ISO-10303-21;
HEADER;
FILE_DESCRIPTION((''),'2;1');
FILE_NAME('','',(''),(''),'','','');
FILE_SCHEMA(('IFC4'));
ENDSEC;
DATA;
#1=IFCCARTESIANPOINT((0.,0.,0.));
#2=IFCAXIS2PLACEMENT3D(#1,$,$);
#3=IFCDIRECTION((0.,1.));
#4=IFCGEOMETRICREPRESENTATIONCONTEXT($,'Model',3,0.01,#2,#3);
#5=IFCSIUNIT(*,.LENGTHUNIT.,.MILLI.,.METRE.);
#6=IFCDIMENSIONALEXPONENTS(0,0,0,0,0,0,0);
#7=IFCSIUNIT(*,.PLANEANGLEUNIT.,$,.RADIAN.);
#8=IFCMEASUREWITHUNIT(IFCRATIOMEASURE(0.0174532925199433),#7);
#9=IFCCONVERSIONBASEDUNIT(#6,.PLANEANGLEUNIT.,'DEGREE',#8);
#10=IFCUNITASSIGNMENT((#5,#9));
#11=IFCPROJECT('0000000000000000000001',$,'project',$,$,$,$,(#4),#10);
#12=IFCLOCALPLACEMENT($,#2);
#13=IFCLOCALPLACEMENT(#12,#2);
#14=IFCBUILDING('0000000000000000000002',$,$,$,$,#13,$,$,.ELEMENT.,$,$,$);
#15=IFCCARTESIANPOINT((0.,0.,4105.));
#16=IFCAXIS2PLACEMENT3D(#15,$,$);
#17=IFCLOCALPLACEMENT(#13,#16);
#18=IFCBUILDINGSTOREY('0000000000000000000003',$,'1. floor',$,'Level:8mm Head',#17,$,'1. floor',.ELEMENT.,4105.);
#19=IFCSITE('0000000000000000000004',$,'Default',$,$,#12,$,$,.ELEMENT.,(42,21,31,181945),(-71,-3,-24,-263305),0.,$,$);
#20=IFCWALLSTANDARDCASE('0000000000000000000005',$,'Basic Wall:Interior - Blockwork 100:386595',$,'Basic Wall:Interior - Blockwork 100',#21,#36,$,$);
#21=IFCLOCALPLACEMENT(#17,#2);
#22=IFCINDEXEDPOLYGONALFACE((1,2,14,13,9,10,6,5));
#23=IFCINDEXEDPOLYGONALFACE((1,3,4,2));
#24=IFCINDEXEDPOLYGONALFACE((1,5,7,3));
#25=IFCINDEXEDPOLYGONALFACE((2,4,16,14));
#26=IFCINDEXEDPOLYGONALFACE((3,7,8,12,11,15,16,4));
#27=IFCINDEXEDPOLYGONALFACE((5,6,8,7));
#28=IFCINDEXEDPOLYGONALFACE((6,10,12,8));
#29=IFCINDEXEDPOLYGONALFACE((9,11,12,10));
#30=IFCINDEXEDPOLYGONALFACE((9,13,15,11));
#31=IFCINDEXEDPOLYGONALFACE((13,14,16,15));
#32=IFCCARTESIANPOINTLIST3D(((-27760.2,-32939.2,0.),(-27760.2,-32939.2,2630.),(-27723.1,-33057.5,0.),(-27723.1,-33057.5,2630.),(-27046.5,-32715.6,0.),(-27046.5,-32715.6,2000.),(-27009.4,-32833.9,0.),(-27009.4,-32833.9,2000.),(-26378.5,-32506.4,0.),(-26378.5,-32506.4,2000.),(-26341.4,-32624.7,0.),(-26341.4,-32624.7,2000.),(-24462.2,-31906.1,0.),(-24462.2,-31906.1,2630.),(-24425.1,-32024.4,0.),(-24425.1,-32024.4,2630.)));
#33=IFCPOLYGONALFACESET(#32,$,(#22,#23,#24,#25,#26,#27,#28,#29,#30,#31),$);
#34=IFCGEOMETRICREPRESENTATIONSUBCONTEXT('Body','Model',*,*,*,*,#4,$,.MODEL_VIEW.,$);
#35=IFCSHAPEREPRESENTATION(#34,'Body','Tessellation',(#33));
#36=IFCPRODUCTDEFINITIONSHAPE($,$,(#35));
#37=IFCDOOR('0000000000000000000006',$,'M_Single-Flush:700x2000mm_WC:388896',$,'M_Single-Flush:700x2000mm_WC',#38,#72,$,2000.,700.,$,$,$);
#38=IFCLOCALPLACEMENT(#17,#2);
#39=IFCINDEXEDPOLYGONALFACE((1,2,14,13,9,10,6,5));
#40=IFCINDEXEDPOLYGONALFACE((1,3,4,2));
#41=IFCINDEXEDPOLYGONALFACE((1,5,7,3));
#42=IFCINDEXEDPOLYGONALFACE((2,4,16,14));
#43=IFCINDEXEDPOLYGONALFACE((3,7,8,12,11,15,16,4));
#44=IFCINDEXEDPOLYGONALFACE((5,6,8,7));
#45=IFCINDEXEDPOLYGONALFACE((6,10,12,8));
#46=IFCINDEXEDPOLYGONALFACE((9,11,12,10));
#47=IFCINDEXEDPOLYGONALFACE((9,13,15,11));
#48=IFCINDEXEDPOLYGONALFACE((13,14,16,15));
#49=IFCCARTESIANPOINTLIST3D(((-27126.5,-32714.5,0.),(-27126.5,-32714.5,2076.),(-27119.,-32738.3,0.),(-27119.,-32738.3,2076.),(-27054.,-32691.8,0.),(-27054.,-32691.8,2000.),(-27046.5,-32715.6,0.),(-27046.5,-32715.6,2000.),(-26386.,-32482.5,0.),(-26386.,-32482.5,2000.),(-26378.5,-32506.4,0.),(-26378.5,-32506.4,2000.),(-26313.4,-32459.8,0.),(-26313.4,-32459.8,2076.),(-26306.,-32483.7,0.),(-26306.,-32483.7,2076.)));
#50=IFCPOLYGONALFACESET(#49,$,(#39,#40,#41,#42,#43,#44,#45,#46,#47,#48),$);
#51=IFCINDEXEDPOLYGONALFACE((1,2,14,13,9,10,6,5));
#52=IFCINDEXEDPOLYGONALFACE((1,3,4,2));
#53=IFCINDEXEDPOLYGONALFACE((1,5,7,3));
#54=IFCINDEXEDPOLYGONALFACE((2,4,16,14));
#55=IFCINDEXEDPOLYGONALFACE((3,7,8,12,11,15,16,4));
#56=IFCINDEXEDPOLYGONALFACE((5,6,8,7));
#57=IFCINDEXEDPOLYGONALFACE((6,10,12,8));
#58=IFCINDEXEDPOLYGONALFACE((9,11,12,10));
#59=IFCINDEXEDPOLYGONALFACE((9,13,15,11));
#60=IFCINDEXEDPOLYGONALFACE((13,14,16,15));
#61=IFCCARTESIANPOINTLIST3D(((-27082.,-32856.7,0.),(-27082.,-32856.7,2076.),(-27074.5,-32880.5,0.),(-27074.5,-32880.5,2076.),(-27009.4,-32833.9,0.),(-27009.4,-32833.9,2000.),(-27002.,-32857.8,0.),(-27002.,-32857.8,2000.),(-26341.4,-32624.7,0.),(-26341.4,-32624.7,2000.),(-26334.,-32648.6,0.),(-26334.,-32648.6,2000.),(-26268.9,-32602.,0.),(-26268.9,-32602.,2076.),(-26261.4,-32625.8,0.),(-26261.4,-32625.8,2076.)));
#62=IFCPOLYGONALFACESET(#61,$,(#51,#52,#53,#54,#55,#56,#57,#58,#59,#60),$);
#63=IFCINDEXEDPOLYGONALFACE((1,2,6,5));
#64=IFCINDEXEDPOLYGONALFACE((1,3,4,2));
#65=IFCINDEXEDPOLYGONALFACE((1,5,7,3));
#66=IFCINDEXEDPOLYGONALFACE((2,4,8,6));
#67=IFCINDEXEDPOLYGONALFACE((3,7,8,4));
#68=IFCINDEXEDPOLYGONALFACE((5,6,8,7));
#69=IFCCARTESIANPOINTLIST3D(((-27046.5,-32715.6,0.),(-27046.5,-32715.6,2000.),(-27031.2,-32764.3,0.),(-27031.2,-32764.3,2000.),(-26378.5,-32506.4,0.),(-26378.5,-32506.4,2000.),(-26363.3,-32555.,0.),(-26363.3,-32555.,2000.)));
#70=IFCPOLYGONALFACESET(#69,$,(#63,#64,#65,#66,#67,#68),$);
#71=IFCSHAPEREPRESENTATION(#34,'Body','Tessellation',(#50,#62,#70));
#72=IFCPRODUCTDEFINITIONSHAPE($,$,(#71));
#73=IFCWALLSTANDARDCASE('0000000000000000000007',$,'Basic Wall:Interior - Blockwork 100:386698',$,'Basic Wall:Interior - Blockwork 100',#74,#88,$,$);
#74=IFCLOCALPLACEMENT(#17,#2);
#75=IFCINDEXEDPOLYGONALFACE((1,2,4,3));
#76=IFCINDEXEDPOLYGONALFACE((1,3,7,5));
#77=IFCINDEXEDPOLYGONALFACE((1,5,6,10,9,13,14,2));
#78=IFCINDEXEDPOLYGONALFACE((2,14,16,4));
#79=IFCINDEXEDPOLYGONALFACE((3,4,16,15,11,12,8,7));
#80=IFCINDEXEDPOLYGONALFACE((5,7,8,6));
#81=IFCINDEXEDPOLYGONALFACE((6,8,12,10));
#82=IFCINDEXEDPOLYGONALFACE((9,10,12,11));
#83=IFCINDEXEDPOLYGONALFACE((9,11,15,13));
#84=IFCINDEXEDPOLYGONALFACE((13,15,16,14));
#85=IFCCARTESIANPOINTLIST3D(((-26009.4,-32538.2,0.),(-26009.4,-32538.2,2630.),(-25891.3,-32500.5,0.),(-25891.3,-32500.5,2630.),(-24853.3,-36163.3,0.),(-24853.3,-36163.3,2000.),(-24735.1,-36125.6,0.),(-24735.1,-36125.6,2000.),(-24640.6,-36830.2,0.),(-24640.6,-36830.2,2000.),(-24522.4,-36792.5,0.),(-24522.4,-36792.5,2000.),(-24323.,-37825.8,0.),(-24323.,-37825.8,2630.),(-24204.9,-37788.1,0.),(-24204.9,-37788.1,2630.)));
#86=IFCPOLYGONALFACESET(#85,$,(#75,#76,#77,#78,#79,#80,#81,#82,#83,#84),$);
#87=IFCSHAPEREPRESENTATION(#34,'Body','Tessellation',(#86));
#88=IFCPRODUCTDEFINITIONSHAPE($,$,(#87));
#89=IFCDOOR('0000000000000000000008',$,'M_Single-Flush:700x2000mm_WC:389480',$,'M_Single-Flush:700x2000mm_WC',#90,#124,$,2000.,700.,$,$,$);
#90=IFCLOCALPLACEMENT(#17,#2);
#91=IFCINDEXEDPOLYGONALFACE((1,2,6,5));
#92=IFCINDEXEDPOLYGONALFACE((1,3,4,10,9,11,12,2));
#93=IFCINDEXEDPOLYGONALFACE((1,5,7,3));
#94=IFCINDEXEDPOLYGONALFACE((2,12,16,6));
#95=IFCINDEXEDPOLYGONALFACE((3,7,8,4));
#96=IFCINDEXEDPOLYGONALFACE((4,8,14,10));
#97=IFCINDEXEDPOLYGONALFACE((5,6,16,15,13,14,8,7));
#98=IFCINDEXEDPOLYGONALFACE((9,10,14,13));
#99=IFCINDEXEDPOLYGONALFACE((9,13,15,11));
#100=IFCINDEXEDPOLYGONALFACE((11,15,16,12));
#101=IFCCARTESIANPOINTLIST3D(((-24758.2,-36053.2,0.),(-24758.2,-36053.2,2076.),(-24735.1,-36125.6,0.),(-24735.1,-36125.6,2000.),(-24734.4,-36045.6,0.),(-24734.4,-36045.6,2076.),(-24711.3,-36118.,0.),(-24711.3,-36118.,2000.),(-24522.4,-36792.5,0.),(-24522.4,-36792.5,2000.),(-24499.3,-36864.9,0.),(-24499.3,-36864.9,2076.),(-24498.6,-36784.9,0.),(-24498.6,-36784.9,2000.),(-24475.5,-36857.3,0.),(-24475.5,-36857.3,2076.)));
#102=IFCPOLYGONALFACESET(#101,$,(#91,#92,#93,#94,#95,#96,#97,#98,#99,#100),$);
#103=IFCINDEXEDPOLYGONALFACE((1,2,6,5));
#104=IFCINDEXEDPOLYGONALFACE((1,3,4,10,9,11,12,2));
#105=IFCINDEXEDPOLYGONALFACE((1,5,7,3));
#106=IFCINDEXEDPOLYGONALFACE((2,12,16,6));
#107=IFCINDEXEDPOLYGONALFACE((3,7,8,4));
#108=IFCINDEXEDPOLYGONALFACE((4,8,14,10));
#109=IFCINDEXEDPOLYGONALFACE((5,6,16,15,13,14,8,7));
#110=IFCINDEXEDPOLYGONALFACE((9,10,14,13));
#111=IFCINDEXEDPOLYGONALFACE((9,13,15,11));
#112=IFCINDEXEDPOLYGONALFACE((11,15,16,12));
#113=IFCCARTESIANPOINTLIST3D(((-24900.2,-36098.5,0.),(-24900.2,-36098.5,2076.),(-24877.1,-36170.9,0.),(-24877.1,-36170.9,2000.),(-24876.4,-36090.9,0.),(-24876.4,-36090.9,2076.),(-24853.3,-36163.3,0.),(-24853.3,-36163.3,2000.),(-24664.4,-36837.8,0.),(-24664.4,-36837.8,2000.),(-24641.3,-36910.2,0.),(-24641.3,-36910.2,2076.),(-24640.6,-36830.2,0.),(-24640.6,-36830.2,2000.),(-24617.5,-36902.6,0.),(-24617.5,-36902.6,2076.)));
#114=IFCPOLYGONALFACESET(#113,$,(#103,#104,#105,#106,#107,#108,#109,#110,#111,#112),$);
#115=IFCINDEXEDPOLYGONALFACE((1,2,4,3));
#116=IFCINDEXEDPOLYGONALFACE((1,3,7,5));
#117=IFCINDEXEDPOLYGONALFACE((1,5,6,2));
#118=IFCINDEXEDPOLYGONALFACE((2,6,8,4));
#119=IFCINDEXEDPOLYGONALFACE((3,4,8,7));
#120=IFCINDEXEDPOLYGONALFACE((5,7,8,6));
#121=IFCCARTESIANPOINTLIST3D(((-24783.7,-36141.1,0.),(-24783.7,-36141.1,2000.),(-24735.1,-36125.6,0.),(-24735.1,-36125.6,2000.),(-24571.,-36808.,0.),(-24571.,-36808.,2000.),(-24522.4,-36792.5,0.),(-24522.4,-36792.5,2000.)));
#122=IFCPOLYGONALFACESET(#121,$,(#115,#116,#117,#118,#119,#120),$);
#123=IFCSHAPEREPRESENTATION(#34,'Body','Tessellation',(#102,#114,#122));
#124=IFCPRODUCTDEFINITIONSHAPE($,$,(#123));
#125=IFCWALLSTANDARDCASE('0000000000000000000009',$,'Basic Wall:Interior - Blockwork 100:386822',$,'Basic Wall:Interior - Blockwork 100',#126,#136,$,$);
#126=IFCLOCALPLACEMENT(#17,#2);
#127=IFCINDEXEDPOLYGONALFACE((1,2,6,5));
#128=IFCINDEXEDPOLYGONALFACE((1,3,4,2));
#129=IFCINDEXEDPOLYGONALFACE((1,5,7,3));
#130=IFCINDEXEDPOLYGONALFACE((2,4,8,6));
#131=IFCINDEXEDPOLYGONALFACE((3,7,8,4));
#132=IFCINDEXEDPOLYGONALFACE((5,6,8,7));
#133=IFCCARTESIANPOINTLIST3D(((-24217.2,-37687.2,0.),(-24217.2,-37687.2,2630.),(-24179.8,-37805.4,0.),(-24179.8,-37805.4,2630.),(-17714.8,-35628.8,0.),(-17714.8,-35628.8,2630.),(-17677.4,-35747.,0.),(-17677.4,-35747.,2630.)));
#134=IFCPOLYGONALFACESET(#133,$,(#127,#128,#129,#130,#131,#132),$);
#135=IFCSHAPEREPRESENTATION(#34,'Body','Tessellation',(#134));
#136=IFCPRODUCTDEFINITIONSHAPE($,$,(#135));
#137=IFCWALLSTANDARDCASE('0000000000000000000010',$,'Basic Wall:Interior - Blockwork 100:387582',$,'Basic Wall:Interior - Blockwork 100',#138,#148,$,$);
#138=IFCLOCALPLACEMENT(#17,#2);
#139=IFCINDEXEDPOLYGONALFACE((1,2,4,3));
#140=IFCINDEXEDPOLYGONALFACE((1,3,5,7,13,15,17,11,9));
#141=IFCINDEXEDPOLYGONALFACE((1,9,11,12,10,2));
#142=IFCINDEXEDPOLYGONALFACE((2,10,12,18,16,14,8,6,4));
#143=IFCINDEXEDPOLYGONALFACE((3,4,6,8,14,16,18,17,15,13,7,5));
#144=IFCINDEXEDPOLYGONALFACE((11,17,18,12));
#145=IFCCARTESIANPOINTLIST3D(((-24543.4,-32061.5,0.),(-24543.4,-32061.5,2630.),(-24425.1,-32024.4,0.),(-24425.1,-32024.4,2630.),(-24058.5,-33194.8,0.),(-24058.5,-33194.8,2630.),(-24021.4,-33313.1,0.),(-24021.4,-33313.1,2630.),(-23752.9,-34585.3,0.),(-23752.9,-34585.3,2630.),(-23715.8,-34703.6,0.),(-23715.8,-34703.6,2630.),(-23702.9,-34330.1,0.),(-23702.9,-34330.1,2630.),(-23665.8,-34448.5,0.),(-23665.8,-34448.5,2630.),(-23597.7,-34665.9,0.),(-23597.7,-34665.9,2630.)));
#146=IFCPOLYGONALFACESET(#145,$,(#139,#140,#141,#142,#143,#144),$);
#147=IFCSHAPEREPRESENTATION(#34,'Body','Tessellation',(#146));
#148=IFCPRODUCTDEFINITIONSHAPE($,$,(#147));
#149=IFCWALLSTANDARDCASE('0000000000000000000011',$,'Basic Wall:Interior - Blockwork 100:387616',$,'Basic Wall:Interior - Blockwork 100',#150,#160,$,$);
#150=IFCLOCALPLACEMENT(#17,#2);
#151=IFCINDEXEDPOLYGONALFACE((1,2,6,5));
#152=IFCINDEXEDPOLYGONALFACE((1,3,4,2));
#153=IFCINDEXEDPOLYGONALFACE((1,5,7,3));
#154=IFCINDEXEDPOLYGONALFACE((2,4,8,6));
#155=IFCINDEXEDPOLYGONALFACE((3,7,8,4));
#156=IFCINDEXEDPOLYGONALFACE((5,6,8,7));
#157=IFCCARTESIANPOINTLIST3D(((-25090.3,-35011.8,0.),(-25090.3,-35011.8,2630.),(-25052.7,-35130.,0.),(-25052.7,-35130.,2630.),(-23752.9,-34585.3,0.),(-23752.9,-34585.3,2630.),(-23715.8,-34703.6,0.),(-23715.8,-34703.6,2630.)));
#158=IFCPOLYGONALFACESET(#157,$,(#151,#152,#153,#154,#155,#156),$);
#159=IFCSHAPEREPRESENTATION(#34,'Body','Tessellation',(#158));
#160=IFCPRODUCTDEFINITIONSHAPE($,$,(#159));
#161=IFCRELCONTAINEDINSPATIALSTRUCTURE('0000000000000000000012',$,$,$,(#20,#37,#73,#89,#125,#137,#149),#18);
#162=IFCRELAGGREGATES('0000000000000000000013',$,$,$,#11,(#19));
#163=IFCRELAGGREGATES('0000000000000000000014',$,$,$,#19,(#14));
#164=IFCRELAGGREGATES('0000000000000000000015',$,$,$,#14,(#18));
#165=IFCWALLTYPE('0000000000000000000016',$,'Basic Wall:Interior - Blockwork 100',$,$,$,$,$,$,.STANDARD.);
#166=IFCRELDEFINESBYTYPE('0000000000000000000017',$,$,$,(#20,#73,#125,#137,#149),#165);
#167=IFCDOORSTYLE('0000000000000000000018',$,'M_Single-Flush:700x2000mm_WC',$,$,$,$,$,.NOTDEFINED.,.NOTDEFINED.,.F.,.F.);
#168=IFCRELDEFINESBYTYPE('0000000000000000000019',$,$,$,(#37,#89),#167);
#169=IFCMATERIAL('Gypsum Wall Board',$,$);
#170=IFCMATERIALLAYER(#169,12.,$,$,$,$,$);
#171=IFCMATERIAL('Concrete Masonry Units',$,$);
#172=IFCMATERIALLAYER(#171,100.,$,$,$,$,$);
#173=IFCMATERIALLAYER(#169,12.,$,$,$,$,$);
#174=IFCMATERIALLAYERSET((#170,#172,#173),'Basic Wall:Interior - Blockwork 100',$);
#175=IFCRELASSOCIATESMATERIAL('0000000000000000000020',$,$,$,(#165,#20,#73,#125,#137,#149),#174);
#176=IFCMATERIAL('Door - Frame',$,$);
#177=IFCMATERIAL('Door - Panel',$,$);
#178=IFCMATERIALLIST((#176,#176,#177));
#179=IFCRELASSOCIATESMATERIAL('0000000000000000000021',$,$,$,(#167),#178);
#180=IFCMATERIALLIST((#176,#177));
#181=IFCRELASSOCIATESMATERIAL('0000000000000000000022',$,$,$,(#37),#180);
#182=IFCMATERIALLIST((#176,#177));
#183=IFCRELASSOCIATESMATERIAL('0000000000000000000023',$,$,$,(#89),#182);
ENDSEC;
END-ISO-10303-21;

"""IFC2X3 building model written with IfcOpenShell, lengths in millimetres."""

from ifc_helpers import new_model, entity, si_unit, converted_unit, direction, frame, frame_2d, origin, origin_2d_with_axis, place, context, subcontext, project, spatial, polyline, rectangle, outline, extrude, source, transform, mapped, material, material_list, layer, layer_set, layer_usage, type_object, type_shapes, element, fill, save


model = new_model("IFC2X3")

# Units and contexts
model_context = context("Model", 3, precision=0.01, world=origin(), true_north=direction((0.0, 1.0)))
body_context = subcontext(model_context, "Body", "Model", "MODEL_VIEW")
ifc_project = project(units=[si_unit("LENGTHUNIT", "METRE", prefix="MILLI"), converted_unit("PLANEANGLEUNIT", "DEGREE", entity("IfcRatioMeasure", 0.0174532925199433), si_unit("PLANEANGLEUNIT", "RADIAN"), dimensions=[0, 0, 0, 0, 0, 0, 0])], contexts=[model_context])

# Site, building, storey
site_placement = place(None, origin())
site = spatial("IfcSite", under=ifc_project, at=site_placement, Name="Default", CompositionType="ELEMENT", RefLatitude=(42, 21, 31, 181945), RefLongitude=(-71, -3, -24, -263305), RefElevation=0.0)
building_placement = place(site_placement, origin())
building = spatial("IfcBuilding", under=site, at=building_placement, CompositionType="ELEMENT")
storey_placement = place(building_placement, frame((0.0, 0.0, 4105.0)))
storey = spatial("IfcBuildingStorey", under=building, at=storey_placement, Name="1. floor", ObjectType="Level:8mm Head", LongName="1. floor", CompositionType="ELEMENT", Elevation=4105.0)

# Walls, openings, doors
ifc_material_1 = material(Name="Gypsum Wall Board")
ifc_layer_1 = layer(ifc_material_1, 12.0)
ifc_material_2 = material(Name="Concrete Masonry Units")
ifc_layer_2 = layer(ifc_material_2, 100.0)
ifc_layer_3 = layer(ifc_material_1, 12.0)
ifc_layer_set = layer_set([ifc_layer_1, ifc_layer_2, ifc_layer_3], Name="Basic Wall:Interior - Blockwork 100")
ifc_layer_usage_1 = layer_usage(ifc_layer_set, "AXIS2", "NEGATIVE", 62.0)
wall_type = type_object("IfcWallType", Name="Basic Wall:Interior - Blockwork 100", PredefinedType="STANDARD", material=ifc_layer_set)
wall_1_placement = place(storey_placement, frame((-27741.6, -32998.3, 0.0), z_axis=(0.0, 0.0, 1.0), x_axis=(0.954277, 0.298924, 0.0)))
wall_1 = element("IfcWallStandardCase", 1, at=wall_1_placement, inside=storey, type_object=wall_type, material=ifc_layer_usage_1, Name="Basic Wall:Interior - Blockwork 100:386595", ObjectType="Basic Wall:Interior - Blockwork 100", context=body_context, shape_type="SweptSolid", body=[
    extrude(rectangle(XDim=3456.0, YDim=124.0, at=frame_2d((1728.0, 0.0), x_axis=(-1.0, 0.0))), origin(), (0.0, 0.0, 1.0), 2630.0),
])
opening_1_placement = place(wall_1_placement, frame((747.9, -62.0, 0.0)))
opening_1 = element("IfcOpeningElement", 2, at=opening_1_placement, cuts=wall_1, ObjectType="Opening", context=body_context, shape_type="SweptSolid", body=[
    extrude(rectangle(XDim=700.0, YDim=2000.0, at=frame_2d((1000.0, 350.0), x_axis=(0.0, 1.0))), frame((0.0, 0.0, 0.0), z_axis=(0.0, 1.0, 0.0), x_axis=(0.0, 0.0, 1.0)), (0.0, 0.0, 1.0), 124.0),
])
ifc_material_3 = material(Name="Door - Frame")
ifc_material_4 = material(Name="Door - Panel")
ifc_material_list_1 = material_list([ifc_material_3, ifc_material_4])
ifc_material_list_2 = material_list([ifc_material_3, ifc_material_3, ifc_material_4])
door_style_1 = type_object("IfcDoorStyle", Name="M_Single-Flush:700x2000mm_WC", ConstructionType="NOTDEFINED", OperationType="NOTDEFINED", ParameterTakesPrecedence=False, Sizeable=False, material=ifc_material_list_2)
shared_shape_1 = source(origin(), body_context, "Body", "SweptSolid", [
    extrude(outline(polyline([(-426.0, -1057.0), (426.0, -1057.0), (426.0, 1019.0), (350.0, 1019.0), (350.0, -981.0), (-350.0, -981.0), (-350.0, 1019.0), (-426.0, 1019.0), (-426.0, -1057.0)])), frame((350.0, 124.0, 1019.0), z_axis=(0.0, 1.0, 0.0), x_axis=(1.0, 0.0, 0.0)), (0.0, 0.0, 1.0), 25.0),
    extrude(outline(polyline([(-1057.0, -426.0), (1019.0, -426.0), (1019.0, -350.0), (-981.0, -350.0), (-981.0, 350.0), (1019.0, 350.0), (1019.0, 426.0), (-1057.0, 426.0), (-1057.0, -426.0)])), frame((350.0, -25.0, 1019.0), z_axis=(0.0, 1.0, 0.0), x_axis=(0.0, 0.0, -1.0)), (0.0, 0.0, 1.0), 25.0),
    extrude(rectangle(XDim=51.0, YDim=700.0, at=origin_2d_with_axis()), frame((350.0, 98.5, 0.0), z_axis=(0.0, 0.0, 1.0), x_axis=(0.0, 1.0, 0.0)), (0.0, 0.0, 1.0), 2000.0),
])
type_shapes(door_style_1, [shared_shape_1])
door_1_placement = place(opening_1_placement, origin())
door_1 = element("IfcDoor", 3, at=door_1_placement, inside=storey, type_object=door_style_1, material=ifc_material_list_1, Name="M_Single-Flush:700x2000mm_WC:388896", ObjectType="M_Single-Flush:700x2000mm_WC", OverallHeight=2000.0, OverallWidth=700.0, context=body_context, shape_type="MappedRepresentation", body=[
    mapped(shared_shape_1, transform((0.0, 0.0, 0.0), scale=1.0)),
])
fill(opening_1, door_1)
ifc_layer_usage_2 = layer_usage(ifc_layer_set, "AXIS2", "NEGATIVE", 62.0)
wall_2_placement = place(storey_placement, frame((-25950.4, -32519.3, 0.0), z_axis=(0.0, 0.0, 1.0), x_axis=(0.303856, -0.952718, 0.0)))
wall_2 = element("IfcWallStandardCase", 4, at=wall_2_placement, inside=storey, type_object=wall_type, material=ifc_layer_usage_2, Name="Basic Wall:Interior - Blockwork 100:386698", ObjectType="Basic Wall:Interior - Blockwork 100", context=body_context, shape_type="SweptSolid", body=[
    extrude(rectangle(XDim=5550.1, YDim=124.0, at=frame_2d((2775.0, 0.0), x_axis=(-1.0, 0.0))), origin(), (0.0, 0.0, 1.0), 2630.0),
])
opening_2_placement = place(wall_2_placement, frame((3805.0, -62.0, 0.0)))
opening_2 = element("IfcOpeningElement", 5, at=opening_2_placement, cuts=wall_2, ObjectType="Opening", context=body_context, shape_type="SweptSolid", body=[
    extrude(rectangle(XDim=700.0, YDim=2000.0, at=frame_2d((1000.0, 350.0), x_axis=(0.0, 1.0))), frame((0.0, 0.0, 0.0), z_axis=(0.0, 1.0, 0.0), x_axis=(0.0, 0.0, 1.0)), (0.0, 0.0, 1.0), 124.0),
])
ifc_material_list_3 = material_list([ifc_material_3, ifc_material_4])
door_2_placement = place(opening_2_placement, origin())
door_2 = element("IfcDoor", 6, at=door_2_placement, inside=storey, type_object=door_style_1, material=ifc_material_list_3, Name="M_Single-Flush:700x2000mm_WC:389480", ObjectType="M_Single-Flush:700x2000mm_WC", OverallHeight=2000.0, OverallWidth=700.0, context=body_context, shape_type="MappedRepresentation", body=[
    mapped(shared_shape_1, transform((0.0, 0.0, 0.0), scale=1.0)),
])
fill(opening_2, door_2)

# Walls
ifc_layer_usage_3 = layer_usage(ifc_layer_set, "AXIS2", "NEGATIVE", 62.0)
wall_3_placement = place(storey_placement, frame((-24198.5, -37746.3, 0.0), z_axis=(0.0, 0.0, 1.0), x_axis=(0.953372, 0.301797, 0.0)))
element("IfcWallStandardCase", 7, at=wall_3_placement, inside=storey, type_object=wall_type, material=ifc_layer_usage_3, Name="Basic Wall:Interior - Blockwork 100:386822", ObjectType="Basic Wall:Interior - Blockwork 100", context=body_context, shape_type="SweptSolid", body=[
    extrude(rectangle(XDim=6820.4, YDim=124.0, at=frame_2d((3410.2, 0.0), x_axis=(-1.0, 0.0))), origin(), (0.0, 0.0, 1.0), 2630.0),
])
ifc_layer_usage_4 = layer_usage(ifc_layer_set, "AXIS2", "NEGATIVE", 62.0)
wall_4_placement = place(storey_placement, frame((-24484.3, -32043.0, 0.0), z_axis=(0.0, 0.0, 1.0), x_axis=(0.298924, -0.954277, 0.0)))
element("IfcWallStandardCase", 8, at=wall_4_placement, inside=storey, type_object=wall_type, material=ifc_layer_usage_4, Name="Basic Wall:Interior - Blockwork 100:387582", ObjectType="Basic Wall:Interior - Blockwork 100", context=body_context, shape_type="SweptSolid", body=[
    extrude(outline(polyline([(2768.7, -62.0), (2768.1, 62.0), (2540.2, 62.0), (2416.2, 62.0), (1350.4, 62.0), (1226.4, 62.0), (0.0, 62.0), (0.0, -62.0), (2644.7, -62.0), (2768.7, -62.0)])), origin(), (0.0, 0.0, 1.0), 2630.0),
])
ifc_layer_usage_5 = layer_usage(ifc_layer_set, "AXIS2", "NEGATIVE", 62.0)
wall_5_placement = place(storey_placement, frame((-23734.0, -34644.3, 0.0), z_axis=(0.0, 0.0, 1.0), x_axis=(-0.952718, -0.303856, 0.0)))
element("IfcWallStandardCase", 9, at=wall_5_placement, inside=storey, type_object=wall_type, material=ifc_layer_usage_5, Name="Basic Wall:Interior - Blockwork 100:387616", ObjectType="Basic Wall:Interior - Blockwork 100", context=body_context, shape_type="SweptSolid", body=[
    extrude(outline(polyline([(1403.9, -62.0), (1403.9, 62.0), (0.6, 62.0), (0.0, -62.0), (1403.9, -62.0)])), origin(), (0.0, 0.0, 1.0), 2630.0),
])

save(model, "model.ifc")
